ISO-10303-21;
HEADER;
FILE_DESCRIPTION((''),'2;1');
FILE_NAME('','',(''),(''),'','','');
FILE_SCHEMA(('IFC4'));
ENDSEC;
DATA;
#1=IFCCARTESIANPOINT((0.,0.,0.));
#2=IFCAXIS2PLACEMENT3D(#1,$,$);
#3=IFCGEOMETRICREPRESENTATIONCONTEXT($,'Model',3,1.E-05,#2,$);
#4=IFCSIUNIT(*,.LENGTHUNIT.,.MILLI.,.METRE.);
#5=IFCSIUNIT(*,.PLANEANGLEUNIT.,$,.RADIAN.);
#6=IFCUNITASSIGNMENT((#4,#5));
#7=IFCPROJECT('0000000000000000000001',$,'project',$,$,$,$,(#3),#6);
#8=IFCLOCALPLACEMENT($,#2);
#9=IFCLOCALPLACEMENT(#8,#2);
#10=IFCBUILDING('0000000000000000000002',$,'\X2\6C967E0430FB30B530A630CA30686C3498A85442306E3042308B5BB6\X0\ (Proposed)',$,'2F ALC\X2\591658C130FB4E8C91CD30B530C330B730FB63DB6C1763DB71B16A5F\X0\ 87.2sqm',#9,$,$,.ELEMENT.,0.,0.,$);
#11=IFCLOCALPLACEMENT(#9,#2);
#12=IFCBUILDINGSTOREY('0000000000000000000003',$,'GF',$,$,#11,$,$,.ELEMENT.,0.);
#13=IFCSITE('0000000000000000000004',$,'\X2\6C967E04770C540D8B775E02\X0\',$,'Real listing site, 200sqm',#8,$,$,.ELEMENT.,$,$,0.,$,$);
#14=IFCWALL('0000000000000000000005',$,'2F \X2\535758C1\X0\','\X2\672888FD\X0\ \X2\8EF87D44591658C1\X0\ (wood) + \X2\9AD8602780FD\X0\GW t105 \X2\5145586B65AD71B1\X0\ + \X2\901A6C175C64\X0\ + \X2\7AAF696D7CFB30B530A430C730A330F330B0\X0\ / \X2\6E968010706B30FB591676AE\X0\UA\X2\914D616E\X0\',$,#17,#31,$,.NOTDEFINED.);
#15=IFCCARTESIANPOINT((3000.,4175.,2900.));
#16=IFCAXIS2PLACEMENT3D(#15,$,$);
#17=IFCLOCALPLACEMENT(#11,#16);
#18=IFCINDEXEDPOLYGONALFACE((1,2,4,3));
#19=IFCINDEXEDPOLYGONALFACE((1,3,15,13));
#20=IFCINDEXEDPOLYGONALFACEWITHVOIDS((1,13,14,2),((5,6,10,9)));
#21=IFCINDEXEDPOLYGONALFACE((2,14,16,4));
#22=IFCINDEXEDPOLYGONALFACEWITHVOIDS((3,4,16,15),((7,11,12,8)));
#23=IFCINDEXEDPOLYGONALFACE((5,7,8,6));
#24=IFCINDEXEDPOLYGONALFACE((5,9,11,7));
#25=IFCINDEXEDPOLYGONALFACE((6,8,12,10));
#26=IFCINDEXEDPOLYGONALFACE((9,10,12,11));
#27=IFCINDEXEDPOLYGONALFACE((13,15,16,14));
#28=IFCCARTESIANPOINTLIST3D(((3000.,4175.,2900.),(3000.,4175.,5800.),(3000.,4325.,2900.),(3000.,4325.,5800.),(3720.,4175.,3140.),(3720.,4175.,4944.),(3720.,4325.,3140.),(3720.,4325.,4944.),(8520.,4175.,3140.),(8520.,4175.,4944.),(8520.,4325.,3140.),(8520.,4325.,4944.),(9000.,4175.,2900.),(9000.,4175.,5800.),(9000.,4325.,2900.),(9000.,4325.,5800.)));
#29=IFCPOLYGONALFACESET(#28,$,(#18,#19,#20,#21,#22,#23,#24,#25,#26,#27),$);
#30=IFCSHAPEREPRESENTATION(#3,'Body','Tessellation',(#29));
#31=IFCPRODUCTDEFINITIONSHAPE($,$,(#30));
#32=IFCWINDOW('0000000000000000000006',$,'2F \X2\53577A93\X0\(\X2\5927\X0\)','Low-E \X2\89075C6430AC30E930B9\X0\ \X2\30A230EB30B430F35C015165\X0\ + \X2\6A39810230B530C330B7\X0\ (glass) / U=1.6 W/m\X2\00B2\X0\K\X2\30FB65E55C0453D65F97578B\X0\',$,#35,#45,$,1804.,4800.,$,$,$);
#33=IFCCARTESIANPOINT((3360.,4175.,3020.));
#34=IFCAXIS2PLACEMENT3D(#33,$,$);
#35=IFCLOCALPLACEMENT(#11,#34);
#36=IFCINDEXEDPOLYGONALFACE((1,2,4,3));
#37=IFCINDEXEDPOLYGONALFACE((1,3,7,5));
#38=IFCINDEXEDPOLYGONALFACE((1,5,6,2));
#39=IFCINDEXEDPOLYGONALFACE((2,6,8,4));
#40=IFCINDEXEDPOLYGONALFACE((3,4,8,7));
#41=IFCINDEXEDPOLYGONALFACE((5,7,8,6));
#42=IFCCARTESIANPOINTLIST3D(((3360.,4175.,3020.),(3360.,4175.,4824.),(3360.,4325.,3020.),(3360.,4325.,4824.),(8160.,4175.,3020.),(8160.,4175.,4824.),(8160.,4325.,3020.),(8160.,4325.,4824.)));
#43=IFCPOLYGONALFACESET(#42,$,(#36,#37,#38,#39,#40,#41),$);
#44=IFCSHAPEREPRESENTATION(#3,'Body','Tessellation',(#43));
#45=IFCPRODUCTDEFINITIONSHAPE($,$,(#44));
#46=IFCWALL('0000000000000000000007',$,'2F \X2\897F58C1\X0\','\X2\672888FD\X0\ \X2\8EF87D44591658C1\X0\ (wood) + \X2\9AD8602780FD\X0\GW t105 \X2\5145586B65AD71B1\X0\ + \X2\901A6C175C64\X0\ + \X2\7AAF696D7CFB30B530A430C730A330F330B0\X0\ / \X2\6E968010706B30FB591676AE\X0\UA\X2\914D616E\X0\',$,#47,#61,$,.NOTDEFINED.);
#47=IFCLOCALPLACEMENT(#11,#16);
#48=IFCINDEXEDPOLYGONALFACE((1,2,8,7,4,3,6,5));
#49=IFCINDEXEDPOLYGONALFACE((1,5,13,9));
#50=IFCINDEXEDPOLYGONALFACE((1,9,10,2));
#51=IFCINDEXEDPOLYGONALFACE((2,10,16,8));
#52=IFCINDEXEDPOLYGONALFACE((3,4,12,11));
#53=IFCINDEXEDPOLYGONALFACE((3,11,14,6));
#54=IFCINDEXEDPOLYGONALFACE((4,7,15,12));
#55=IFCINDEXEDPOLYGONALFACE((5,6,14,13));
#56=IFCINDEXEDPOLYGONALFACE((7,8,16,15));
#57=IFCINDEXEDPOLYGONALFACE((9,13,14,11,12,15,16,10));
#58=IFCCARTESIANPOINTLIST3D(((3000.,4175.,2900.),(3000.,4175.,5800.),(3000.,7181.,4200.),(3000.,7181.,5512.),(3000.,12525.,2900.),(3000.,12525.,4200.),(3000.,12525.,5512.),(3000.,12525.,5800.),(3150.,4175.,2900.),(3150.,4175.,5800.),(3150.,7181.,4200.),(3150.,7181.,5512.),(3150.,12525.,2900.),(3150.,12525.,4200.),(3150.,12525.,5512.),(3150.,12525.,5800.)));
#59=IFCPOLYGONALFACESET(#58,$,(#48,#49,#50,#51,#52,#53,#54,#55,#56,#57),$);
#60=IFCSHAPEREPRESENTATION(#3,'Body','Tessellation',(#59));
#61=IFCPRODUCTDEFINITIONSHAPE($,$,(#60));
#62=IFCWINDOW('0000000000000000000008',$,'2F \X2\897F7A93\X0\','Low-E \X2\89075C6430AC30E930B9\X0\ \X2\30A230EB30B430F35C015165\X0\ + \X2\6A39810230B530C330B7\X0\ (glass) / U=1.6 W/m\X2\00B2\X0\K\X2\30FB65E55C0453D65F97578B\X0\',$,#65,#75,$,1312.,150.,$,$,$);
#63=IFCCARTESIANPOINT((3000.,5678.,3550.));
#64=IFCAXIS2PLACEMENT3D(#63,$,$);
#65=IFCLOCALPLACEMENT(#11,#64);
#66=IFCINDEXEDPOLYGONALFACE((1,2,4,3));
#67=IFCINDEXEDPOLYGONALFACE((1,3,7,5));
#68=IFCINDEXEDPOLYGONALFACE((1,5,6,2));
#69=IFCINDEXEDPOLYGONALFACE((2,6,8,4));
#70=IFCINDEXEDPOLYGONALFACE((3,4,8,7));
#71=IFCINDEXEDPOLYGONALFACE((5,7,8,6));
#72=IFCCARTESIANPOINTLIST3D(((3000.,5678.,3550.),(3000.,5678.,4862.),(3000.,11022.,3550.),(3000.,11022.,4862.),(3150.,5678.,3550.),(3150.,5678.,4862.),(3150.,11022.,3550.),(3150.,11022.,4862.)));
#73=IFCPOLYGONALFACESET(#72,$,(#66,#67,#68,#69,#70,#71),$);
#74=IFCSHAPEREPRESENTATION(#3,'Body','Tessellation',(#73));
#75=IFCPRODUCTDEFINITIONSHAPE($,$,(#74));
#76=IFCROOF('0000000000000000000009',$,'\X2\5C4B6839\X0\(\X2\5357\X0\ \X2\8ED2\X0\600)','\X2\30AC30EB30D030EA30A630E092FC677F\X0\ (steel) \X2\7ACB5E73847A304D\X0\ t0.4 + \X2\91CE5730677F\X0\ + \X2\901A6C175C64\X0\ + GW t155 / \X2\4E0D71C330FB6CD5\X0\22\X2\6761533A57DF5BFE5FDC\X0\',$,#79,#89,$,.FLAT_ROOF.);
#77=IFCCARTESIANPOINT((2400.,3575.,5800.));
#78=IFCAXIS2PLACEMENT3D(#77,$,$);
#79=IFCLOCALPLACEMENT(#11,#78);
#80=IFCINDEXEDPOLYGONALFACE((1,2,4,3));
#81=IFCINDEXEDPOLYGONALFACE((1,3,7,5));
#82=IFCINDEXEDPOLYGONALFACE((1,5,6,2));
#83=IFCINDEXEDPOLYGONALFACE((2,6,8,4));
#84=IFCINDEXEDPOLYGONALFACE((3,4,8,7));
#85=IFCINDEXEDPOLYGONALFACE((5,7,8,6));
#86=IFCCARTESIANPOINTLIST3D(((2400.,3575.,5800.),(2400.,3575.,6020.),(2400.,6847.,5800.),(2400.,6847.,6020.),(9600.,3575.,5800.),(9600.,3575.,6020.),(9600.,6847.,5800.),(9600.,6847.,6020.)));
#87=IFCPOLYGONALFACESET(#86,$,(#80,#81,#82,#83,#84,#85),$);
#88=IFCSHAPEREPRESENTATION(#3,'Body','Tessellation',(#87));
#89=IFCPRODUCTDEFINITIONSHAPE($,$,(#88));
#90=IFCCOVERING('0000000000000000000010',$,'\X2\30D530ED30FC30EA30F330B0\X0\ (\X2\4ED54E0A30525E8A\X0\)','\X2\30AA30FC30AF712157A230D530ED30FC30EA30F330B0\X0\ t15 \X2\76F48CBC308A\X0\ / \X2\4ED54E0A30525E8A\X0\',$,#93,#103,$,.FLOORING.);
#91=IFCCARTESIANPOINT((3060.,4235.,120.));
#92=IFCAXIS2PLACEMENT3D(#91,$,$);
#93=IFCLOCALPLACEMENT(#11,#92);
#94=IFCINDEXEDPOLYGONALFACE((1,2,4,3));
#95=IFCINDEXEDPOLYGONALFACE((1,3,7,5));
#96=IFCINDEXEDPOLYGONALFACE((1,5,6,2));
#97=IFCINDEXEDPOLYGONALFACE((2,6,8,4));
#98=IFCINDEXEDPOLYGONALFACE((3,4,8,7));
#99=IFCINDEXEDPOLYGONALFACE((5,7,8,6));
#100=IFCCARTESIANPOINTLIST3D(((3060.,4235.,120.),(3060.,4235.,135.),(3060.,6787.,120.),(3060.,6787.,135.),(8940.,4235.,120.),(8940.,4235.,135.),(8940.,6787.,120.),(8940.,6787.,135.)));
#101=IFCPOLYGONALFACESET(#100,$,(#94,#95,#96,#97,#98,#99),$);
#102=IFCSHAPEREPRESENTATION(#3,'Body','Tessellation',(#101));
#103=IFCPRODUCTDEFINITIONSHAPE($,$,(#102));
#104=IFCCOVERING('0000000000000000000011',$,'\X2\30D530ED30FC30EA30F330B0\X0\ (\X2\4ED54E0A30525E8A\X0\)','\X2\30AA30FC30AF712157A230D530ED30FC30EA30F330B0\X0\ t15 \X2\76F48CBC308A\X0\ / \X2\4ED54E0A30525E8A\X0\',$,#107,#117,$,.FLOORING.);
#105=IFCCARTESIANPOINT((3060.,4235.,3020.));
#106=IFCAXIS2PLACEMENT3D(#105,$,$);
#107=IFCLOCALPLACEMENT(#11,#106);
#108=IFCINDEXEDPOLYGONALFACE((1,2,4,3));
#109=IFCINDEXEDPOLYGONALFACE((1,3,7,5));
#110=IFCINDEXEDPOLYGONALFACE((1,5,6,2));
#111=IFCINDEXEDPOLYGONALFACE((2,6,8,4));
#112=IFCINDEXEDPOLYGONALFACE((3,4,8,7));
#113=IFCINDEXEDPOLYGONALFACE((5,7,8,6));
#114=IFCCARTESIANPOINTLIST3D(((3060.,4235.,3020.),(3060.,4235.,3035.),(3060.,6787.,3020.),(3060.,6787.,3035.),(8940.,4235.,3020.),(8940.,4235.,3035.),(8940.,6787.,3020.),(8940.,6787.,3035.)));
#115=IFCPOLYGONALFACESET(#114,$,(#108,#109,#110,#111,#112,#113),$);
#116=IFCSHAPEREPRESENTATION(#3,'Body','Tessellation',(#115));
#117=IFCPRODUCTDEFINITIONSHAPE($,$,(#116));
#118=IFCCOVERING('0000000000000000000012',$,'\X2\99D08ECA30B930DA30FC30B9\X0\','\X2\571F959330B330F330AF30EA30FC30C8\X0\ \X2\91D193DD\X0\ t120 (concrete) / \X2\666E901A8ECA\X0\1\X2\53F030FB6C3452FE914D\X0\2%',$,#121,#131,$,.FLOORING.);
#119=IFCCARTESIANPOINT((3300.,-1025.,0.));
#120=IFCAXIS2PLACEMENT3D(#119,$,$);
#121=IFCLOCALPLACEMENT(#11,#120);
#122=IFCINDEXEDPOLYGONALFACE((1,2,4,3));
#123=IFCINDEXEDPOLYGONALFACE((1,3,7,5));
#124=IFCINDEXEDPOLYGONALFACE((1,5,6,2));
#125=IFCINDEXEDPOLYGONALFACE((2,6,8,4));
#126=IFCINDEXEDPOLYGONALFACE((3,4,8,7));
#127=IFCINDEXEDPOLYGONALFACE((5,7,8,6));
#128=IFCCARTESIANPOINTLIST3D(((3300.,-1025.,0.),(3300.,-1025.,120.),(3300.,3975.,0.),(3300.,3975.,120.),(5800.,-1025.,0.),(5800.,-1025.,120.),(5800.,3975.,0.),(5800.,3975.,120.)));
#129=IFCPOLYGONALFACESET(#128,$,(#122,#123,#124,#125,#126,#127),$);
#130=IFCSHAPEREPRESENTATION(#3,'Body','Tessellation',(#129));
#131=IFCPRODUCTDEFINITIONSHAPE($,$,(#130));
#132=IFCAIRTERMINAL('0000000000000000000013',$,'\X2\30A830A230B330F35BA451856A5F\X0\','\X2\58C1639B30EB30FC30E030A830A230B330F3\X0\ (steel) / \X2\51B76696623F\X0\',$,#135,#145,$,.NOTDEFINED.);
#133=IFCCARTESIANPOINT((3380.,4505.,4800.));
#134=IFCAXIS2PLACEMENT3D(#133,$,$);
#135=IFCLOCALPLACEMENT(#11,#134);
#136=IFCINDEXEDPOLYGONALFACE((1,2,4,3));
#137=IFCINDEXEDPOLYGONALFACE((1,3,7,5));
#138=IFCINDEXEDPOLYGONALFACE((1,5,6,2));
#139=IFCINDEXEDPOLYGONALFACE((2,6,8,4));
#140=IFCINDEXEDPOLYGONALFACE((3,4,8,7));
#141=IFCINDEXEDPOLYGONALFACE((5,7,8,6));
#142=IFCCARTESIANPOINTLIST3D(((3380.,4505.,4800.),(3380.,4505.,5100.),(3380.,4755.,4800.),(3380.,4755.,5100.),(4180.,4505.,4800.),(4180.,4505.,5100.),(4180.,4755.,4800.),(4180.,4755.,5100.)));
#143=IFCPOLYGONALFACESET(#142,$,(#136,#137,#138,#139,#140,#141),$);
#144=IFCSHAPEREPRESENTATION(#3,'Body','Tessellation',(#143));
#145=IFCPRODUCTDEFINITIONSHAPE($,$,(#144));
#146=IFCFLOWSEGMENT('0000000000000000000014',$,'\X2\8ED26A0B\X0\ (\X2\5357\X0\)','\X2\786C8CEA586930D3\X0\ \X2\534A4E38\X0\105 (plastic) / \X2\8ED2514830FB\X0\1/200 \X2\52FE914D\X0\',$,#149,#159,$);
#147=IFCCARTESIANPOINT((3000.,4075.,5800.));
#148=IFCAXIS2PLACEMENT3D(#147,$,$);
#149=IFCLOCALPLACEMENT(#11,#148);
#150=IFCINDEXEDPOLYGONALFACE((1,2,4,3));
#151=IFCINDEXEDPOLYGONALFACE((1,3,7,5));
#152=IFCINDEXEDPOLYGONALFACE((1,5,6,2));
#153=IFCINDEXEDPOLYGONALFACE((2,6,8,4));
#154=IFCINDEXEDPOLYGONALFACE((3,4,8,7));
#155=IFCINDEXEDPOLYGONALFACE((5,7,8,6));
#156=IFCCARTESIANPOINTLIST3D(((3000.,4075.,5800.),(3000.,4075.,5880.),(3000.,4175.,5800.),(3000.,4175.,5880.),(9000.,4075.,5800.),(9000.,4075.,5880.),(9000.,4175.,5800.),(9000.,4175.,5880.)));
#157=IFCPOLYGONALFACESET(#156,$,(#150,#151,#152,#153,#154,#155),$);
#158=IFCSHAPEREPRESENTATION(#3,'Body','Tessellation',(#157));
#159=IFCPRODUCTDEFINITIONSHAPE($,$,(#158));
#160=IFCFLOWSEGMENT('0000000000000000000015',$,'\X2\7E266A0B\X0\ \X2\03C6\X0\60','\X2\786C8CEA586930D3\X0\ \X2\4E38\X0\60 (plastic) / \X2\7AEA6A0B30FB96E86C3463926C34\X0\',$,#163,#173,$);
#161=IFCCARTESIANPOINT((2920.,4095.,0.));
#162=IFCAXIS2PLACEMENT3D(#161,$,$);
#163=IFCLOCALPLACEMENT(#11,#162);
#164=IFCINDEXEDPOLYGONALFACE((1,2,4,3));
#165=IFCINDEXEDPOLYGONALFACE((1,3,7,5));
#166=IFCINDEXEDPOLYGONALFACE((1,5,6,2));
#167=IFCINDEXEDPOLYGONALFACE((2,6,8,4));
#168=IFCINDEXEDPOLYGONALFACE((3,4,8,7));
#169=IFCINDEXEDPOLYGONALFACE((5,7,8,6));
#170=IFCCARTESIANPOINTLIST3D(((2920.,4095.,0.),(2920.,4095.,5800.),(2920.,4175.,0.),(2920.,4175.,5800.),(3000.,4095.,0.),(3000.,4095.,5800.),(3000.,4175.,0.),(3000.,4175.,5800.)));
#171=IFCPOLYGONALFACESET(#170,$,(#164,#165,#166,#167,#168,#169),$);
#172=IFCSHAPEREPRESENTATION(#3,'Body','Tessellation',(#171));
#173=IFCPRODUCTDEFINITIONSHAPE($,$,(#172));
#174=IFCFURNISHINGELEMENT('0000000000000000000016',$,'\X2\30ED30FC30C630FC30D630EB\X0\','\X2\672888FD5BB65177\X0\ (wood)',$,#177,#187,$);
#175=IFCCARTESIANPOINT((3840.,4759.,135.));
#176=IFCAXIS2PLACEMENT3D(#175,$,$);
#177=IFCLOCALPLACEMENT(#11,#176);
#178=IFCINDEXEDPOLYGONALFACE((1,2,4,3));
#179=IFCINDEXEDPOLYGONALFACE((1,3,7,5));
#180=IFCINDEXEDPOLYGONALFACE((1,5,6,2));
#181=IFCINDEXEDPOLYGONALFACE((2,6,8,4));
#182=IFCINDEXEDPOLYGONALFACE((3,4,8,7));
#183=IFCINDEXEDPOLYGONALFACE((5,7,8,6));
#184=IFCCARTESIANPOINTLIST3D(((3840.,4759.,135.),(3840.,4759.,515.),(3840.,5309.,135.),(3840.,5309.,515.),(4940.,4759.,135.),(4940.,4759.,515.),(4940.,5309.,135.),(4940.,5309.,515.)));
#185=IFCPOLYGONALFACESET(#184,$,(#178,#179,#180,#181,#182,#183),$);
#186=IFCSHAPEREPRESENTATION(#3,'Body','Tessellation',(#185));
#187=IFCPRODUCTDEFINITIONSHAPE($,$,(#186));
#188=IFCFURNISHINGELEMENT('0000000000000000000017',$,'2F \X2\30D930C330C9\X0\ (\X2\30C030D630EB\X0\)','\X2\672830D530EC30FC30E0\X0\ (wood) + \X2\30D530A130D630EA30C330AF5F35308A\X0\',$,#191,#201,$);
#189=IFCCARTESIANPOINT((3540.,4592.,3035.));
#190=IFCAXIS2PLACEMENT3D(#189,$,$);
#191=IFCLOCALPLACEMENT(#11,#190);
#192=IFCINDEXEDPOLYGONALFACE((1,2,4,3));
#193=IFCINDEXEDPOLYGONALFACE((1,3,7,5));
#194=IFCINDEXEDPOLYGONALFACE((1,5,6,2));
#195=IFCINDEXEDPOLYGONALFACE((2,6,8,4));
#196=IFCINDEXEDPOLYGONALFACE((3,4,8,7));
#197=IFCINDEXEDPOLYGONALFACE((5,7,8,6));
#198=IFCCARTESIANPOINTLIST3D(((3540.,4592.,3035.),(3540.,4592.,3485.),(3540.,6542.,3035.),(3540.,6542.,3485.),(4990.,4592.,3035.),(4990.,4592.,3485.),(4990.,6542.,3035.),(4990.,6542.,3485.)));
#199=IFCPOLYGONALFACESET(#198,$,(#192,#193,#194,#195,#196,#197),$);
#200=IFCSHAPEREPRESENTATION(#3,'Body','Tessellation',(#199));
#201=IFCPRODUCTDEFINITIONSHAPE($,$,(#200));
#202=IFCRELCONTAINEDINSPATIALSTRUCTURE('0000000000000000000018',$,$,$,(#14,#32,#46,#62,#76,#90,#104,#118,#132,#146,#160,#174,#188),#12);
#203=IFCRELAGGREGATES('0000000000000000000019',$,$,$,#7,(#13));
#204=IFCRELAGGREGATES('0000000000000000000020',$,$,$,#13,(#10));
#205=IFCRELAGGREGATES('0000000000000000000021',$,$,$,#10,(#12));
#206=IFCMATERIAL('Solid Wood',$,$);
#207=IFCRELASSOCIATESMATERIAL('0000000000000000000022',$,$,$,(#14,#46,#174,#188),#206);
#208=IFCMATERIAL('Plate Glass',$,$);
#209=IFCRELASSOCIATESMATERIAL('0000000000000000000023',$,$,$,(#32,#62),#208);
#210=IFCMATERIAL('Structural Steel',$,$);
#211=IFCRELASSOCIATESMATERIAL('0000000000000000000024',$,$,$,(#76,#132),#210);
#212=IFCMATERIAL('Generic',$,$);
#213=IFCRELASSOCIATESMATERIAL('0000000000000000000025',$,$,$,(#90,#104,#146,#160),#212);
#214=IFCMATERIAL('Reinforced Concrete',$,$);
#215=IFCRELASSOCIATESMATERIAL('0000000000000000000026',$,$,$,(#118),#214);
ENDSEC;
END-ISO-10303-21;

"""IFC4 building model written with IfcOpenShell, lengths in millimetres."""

from ifc_helpers import new_model, si_unit, frame, frame_2d, origin, place, context, project, spatial, rectangle, extrude, material, element, fill, save


model = new_model("IFC4")

# Units and contexts
model_context = context("Model", 3, precision=1e-05, world=origin())
ifc_project = project(units=[si_unit("LENGTHUNIT", "METRE", prefix="MILLI"), si_unit("PLANEANGLEUNIT", "RADIAN")], contexts=[model_context])

# Site, building, storey
site_placement = place(None, origin())
site = spatial("IfcSite", under=ifc_project, at=site_placement, Name="沖縄県名護市", ObjectType="Real listing site, 200sqm", CompositionType="ELEMENT", RefElevation=0.0)
building_placement = place(site_placement, origin())
building = spatial("IfcBuilding", under=site, at=building_placement, Name="沖縄・サウナと水風呂のある家 (Proposed)", ObjectType="2F ALC外壁・二重サッシ・換気換熱機 87.2sqm", CompositionType="ELEMENT", ElevationOfRefHeight=0.0, ElevationOfTerrain=0.0)
storey_placement = place(building_placement, origin())
storey = spatial("IfcBuildingStorey", under=building, at=storey_placement, Name="GF", CompositionType="ELEMENT", Elevation=0.0)

# Shared definitions
ifc_material_1 = material(Name="Solid Wood")

# Shared definitions
ifc_material_2 = material(Name="Reinforced Concrete")

# Shared definitions
ifc_material_3 = material(Name="Plate Glass")

# Walls, openings, windows
wall_1_placement = place(storey_placement, frame((3000.0, 4175.0, 2900.0)))
wall_1 = element("IfcWall", 1, at=wall_1_placement, inside=storey, material=ifc_material_1, Name="2F 南壁", Description="木製 軸組外壁 (wood) + 高性能GW t105 充填断熱 + 通気層 + 窯業系サイディング / 準耐火・外皮UA配慮", PredefinedType="NOTDEFINED", context=model_context, shape_type="SweptSolid", body=[
    extrude(rectangle(XDim=6000.0, YDim=150.0, at=frame_2d((3000.0, 75.0))), frame((3000.0, 4175.0, 2900.0)), (0.0, 0.0, 1.0), 2900.0),
])
opening_1_placement = place(storey_placement, frame((3360.0, 4175.0, 3020.0)))
opening_1 = element("IfcOpeningElement", 2, at=opening_1_placement, cuts=wall_1, PredefinedType="NOTDEFINED", context=model_context, shape_type="SweptSolid", body=[
    extrude(rectangle(XDim=4800.0, YDim=150.0, at=frame_2d((2400.0, 75.0))), frame((3360.0, 4175.0, 3020.0)), (0.0, 0.0, 1.0), 1804.0),
])
window_1_placement = place(storey_placement, frame((3360.0, 4175.0, 3020.0)))
window_1 = element("IfcWindow", 3, at=window_1_placement, inside=storey, material=ifc_material_3, Name="2F 南窓(大)", Description="Low-E 複層ガラス アルゴン封入 + 樹脂サッシ (glass) / U=1.6 W/m²K・日射取得型", OverallHeight=1804.0, OverallWidth=4800.0, context=model_context, shape_type="SweptSolid", body=[
    extrude(rectangle(XDim=4800.0, YDim=150.0, at=frame_2d((2400.0, 75.0))), frame((3360.0, 4175.0, 3020.0)), (0.0, 0.0, 1.0), 1804.0),
])
fill(opening_1, window_1)
wall_2_placement = place(storey_placement, frame((3000.0, 4175.0, 2900.0)))
wall_2 = element("IfcWall", 4, at=wall_2_placement, inside=storey, material=ifc_material_1, Name="2F 西壁", Description="木製 軸組外壁 (wood) + 高性能GW t105 充填断熱 + 通気層 + 窯業系サイディング / 準耐火・外皮UA配慮", PredefinedType="NOTDEFINED", context=model_context, shape_type="SweptSolid", body=[
    extrude(rectangle(XDim=150.0, YDim=8350.0, at=frame_2d((75.0, 4175.0))), frame((3000.0, 4175.0, 2900.0)), (0.0, 0.0, 1.0), 2900.0),
])
opening_2_placement = place(storey_placement, frame((3000.0, 5678.0, 3550.0)))
opening_2 = element("IfcOpeningElement", 5, at=opening_2_placement, cuts=wall_2, PredefinedType="NOTDEFINED", context=model_context, shape_type="SweptSolid", body=[
    extrude(rectangle(XDim=150.0, YDim=5344.0, at=frame_2d((75.0, 2672.0))), frame((3000.0, 5678.0, 3550.0)), (0.0, 0.0, 1.0), 1312.0),
])
window_2_placement = place(storey_placement, frame((3000.0, 5678.0, 3550.0)))
window_2 = element("IfcWindow", 6, at=window_2_placement, inside=storey, material=ifc_material_3, Name="2F 西窓", Description="Low-E 複層ガラス アルゴン封入 + 樹脂サッシ (glass) / U=1.6 W/m²K・日射取得型", OverallHeight=1312.0, OverallWidth=150.0, context=model_context, shape_type="SweptSolid", body=[
    extrude(rectangle(XDim=150.0, YDim=5344.0, at=frame_2d((75.0, 2672.0))), frame((3000.0, 5678.0, 3550.0)), (0.0, 0.0, 1.0), 1312.0),
])
fill(opening_2, window_2)

# Roof
ifc_material_4 = material(Name="Structural Steel")
for number, where, name in (
    (7, (2400.0, 3575.0, 5800.0), "屋根(南 軒600)"),
):
    element("IfcRoof", number, at=place(storey_placement, frame(where)), inside=storey, material=ifc_material_4, Name=name, Description="ガルバリウム鋼板 (steel) 立平葺き t0.4 + 野地板 + 通気層 + GW t155 / 不燃・法22条区域対応", PredefinedType="FLAT_ROOF", context=model_context, shape_type="SweptSolid", body=[
        extrude(rectangle(XDim=7200.0, YDim=3272.0, at=frame_2d((3600.0, 1636.0))), frame((2400.0, 3575.0, 5800.0)), (0.0, 0.0, 1.0), 220.0),
    ])

# Coverings
ifc_material_5 = material(Name="Generic")
covering_1_placement = place(storey_placement, frame((3060.0, 4235.0, 120.0)))
element("IfcCovering", 8, at=covering_1_placement, inside=storey, material=ifc_material_5, Name="フローリング (仕上げ床)", Description="オーク無垢フローリング t15 直貼り / 仕上げ床", PredefinedType="FLOORING", context=model_context, shape_type="SweptSolid", body=[
    extrude(rectangle(XDim=5880.0, YDim=2552.0, at=frame_2d((2940.0, 1276.0))), frame((3060.0, 4235.0, 120.0)), (0.0, 0.0, 1.0), 15.0),
])
covering_2_placement = place(storey_placement, frame((3060.0, 4235.0, 3020.0)))
element("IfcCovering", 9, at=covering_2_placement, inside=storey, material=ifc_material_5, Name="フローリング (仕上げ床)", Description="オーク無垢フローリング t15 直貼り / 仕上げ床", PredefinedType="FLOORING", context=model_context, shape_type="SweptSolid", body=[
    extrude(rectangle(XDim=5880.0, YDim=2552.0, at=frame_2d((2940.0, 1276.0))), frame((3060.0, 4235.0, 3020.0)), (0.0, 0.0, 1.0), 15.0),
])
covering_3_placement = place(storey_placement, frame((3300.0, -1025.0, 0.0)))
element("IfcCovering", 10, at=covering_3_placement, inside=storey, material=ifc_material_2, Name="駐車スペース", Description="土間コンクリート 金鏝 t120 (concrete) / 普通車1台・水勾配2%", PredefinedType="FLOORING", context=model_context, shape_type="SweptSolid", body=[
    extrude(rectangle(XDim=2500.0, YDim=5000.0, at=frame_2d((1250.0, 2500.0))), frame((3300.0, -1025.0, 0.0)), (0.0, 0.0, 1.0), 120.0),
])

# Air terminal
air_terminal_placement = place(storey_placement, frame((3380.0, 4505.0, 4800.0)))
element("IfcAirTerminal", 11, at=air_terminal_placement, inside=storey, material=ifc_material_4, Name="エアコン室内機", Description="壁掛ルームエアコン (steel) / 冷暖房", PredefinedType="NOTDEFINED", context=model_context, shape_type="SweptSolid", body=[
    extrude(rectangle(XDim=800.0, YDim=250.0, at=frame_2d((400.0, 125.0))), frame((3380.0, 4505.0, 4800.0)), (0.0, 0.0, 1.0), 300.0),
])

# Flow segments
flow_segment_1_placement = place(storey_placement, frame((3000.0, 4075.0, 5800.0)))
element("IfcFlowSegment", 12, at=flow_segment_1_placement, inside=storey, material=ifc_material_5, Name="軒樋 (南)", Description="硬質塩ビ 半丸105 (plastic) / 軒先・1/200 勾配", context=model_context, shape_type="SweptSolid", body=[
    extrude(rectangle(XDim=6000.0, YDim=100.0, at=frame_2d((3000.0, 50.0))), frame((3000.0, 4075.0, 5800.0)), (0.0, 0.0, 1.0), 80.0),
])
flow_segment_2_placement = place(storey_placement, frame((2920.0, 4095.0, 0.0)))
element("IfcFlowSegment", 13, at=flow_segment_2_placement, inside=storey, material=ifc_material_5, Name="縦樋 φ60", Description="硬質塩ビ 丸60 (plastic) / 竪樋・雨水排水", context=model_context, shape_type="SweptSolid", body=[
    extrude(rectangle(XDim=80.0, YDim=80.0, at=frame_2d((40.0, 40.0))), frame((2920.0, 4095.0, 0.0)), (0.0, 0.0, 1.0), 5800.0),
])

# Furnishing elements
furnishing_1_placement = place(storey_placement, frame((3840.0, 4759.0, 135.0)))
element("IfcFurnishingElement", 14, at=furnishing_1_placement, inside=storey, material=ifc_material_1, Name="ローテーブル", Description="木製家具 (wood)", context=model_context, shape_type="SweptSolid", body=[
    extrude(rectangle(XDim=1100.0, YDim=550.0, at=frame_2d((550.0, 275.0))), frame((3840.0, 4759.0, 135.0)), (0.0, 0.0, 1.0), 380.0),
])
furnishing_2_placement = place(storey_placement, frame((3540.0, 4592.0, 3035.0)))
element("IfcFurnishingElement", 15, at=furnishing_2_placement, inside=storey, material=ifc_material_1, Name="2F ベッド (ダブル)", Description="木フレーム (wood) + ファブリック張り", context=model_context, shape_type="SweptSolid", body=[
    extrude(rectangle(XDim=1450.0, YDim=1950.0, at=frame_2d((725.0, 975.0))), frame((3540.0, 4592.0, 3035.0)), (0.0, 0.0, 1.0), 450.0),
])

save(model, "model.ifc")
